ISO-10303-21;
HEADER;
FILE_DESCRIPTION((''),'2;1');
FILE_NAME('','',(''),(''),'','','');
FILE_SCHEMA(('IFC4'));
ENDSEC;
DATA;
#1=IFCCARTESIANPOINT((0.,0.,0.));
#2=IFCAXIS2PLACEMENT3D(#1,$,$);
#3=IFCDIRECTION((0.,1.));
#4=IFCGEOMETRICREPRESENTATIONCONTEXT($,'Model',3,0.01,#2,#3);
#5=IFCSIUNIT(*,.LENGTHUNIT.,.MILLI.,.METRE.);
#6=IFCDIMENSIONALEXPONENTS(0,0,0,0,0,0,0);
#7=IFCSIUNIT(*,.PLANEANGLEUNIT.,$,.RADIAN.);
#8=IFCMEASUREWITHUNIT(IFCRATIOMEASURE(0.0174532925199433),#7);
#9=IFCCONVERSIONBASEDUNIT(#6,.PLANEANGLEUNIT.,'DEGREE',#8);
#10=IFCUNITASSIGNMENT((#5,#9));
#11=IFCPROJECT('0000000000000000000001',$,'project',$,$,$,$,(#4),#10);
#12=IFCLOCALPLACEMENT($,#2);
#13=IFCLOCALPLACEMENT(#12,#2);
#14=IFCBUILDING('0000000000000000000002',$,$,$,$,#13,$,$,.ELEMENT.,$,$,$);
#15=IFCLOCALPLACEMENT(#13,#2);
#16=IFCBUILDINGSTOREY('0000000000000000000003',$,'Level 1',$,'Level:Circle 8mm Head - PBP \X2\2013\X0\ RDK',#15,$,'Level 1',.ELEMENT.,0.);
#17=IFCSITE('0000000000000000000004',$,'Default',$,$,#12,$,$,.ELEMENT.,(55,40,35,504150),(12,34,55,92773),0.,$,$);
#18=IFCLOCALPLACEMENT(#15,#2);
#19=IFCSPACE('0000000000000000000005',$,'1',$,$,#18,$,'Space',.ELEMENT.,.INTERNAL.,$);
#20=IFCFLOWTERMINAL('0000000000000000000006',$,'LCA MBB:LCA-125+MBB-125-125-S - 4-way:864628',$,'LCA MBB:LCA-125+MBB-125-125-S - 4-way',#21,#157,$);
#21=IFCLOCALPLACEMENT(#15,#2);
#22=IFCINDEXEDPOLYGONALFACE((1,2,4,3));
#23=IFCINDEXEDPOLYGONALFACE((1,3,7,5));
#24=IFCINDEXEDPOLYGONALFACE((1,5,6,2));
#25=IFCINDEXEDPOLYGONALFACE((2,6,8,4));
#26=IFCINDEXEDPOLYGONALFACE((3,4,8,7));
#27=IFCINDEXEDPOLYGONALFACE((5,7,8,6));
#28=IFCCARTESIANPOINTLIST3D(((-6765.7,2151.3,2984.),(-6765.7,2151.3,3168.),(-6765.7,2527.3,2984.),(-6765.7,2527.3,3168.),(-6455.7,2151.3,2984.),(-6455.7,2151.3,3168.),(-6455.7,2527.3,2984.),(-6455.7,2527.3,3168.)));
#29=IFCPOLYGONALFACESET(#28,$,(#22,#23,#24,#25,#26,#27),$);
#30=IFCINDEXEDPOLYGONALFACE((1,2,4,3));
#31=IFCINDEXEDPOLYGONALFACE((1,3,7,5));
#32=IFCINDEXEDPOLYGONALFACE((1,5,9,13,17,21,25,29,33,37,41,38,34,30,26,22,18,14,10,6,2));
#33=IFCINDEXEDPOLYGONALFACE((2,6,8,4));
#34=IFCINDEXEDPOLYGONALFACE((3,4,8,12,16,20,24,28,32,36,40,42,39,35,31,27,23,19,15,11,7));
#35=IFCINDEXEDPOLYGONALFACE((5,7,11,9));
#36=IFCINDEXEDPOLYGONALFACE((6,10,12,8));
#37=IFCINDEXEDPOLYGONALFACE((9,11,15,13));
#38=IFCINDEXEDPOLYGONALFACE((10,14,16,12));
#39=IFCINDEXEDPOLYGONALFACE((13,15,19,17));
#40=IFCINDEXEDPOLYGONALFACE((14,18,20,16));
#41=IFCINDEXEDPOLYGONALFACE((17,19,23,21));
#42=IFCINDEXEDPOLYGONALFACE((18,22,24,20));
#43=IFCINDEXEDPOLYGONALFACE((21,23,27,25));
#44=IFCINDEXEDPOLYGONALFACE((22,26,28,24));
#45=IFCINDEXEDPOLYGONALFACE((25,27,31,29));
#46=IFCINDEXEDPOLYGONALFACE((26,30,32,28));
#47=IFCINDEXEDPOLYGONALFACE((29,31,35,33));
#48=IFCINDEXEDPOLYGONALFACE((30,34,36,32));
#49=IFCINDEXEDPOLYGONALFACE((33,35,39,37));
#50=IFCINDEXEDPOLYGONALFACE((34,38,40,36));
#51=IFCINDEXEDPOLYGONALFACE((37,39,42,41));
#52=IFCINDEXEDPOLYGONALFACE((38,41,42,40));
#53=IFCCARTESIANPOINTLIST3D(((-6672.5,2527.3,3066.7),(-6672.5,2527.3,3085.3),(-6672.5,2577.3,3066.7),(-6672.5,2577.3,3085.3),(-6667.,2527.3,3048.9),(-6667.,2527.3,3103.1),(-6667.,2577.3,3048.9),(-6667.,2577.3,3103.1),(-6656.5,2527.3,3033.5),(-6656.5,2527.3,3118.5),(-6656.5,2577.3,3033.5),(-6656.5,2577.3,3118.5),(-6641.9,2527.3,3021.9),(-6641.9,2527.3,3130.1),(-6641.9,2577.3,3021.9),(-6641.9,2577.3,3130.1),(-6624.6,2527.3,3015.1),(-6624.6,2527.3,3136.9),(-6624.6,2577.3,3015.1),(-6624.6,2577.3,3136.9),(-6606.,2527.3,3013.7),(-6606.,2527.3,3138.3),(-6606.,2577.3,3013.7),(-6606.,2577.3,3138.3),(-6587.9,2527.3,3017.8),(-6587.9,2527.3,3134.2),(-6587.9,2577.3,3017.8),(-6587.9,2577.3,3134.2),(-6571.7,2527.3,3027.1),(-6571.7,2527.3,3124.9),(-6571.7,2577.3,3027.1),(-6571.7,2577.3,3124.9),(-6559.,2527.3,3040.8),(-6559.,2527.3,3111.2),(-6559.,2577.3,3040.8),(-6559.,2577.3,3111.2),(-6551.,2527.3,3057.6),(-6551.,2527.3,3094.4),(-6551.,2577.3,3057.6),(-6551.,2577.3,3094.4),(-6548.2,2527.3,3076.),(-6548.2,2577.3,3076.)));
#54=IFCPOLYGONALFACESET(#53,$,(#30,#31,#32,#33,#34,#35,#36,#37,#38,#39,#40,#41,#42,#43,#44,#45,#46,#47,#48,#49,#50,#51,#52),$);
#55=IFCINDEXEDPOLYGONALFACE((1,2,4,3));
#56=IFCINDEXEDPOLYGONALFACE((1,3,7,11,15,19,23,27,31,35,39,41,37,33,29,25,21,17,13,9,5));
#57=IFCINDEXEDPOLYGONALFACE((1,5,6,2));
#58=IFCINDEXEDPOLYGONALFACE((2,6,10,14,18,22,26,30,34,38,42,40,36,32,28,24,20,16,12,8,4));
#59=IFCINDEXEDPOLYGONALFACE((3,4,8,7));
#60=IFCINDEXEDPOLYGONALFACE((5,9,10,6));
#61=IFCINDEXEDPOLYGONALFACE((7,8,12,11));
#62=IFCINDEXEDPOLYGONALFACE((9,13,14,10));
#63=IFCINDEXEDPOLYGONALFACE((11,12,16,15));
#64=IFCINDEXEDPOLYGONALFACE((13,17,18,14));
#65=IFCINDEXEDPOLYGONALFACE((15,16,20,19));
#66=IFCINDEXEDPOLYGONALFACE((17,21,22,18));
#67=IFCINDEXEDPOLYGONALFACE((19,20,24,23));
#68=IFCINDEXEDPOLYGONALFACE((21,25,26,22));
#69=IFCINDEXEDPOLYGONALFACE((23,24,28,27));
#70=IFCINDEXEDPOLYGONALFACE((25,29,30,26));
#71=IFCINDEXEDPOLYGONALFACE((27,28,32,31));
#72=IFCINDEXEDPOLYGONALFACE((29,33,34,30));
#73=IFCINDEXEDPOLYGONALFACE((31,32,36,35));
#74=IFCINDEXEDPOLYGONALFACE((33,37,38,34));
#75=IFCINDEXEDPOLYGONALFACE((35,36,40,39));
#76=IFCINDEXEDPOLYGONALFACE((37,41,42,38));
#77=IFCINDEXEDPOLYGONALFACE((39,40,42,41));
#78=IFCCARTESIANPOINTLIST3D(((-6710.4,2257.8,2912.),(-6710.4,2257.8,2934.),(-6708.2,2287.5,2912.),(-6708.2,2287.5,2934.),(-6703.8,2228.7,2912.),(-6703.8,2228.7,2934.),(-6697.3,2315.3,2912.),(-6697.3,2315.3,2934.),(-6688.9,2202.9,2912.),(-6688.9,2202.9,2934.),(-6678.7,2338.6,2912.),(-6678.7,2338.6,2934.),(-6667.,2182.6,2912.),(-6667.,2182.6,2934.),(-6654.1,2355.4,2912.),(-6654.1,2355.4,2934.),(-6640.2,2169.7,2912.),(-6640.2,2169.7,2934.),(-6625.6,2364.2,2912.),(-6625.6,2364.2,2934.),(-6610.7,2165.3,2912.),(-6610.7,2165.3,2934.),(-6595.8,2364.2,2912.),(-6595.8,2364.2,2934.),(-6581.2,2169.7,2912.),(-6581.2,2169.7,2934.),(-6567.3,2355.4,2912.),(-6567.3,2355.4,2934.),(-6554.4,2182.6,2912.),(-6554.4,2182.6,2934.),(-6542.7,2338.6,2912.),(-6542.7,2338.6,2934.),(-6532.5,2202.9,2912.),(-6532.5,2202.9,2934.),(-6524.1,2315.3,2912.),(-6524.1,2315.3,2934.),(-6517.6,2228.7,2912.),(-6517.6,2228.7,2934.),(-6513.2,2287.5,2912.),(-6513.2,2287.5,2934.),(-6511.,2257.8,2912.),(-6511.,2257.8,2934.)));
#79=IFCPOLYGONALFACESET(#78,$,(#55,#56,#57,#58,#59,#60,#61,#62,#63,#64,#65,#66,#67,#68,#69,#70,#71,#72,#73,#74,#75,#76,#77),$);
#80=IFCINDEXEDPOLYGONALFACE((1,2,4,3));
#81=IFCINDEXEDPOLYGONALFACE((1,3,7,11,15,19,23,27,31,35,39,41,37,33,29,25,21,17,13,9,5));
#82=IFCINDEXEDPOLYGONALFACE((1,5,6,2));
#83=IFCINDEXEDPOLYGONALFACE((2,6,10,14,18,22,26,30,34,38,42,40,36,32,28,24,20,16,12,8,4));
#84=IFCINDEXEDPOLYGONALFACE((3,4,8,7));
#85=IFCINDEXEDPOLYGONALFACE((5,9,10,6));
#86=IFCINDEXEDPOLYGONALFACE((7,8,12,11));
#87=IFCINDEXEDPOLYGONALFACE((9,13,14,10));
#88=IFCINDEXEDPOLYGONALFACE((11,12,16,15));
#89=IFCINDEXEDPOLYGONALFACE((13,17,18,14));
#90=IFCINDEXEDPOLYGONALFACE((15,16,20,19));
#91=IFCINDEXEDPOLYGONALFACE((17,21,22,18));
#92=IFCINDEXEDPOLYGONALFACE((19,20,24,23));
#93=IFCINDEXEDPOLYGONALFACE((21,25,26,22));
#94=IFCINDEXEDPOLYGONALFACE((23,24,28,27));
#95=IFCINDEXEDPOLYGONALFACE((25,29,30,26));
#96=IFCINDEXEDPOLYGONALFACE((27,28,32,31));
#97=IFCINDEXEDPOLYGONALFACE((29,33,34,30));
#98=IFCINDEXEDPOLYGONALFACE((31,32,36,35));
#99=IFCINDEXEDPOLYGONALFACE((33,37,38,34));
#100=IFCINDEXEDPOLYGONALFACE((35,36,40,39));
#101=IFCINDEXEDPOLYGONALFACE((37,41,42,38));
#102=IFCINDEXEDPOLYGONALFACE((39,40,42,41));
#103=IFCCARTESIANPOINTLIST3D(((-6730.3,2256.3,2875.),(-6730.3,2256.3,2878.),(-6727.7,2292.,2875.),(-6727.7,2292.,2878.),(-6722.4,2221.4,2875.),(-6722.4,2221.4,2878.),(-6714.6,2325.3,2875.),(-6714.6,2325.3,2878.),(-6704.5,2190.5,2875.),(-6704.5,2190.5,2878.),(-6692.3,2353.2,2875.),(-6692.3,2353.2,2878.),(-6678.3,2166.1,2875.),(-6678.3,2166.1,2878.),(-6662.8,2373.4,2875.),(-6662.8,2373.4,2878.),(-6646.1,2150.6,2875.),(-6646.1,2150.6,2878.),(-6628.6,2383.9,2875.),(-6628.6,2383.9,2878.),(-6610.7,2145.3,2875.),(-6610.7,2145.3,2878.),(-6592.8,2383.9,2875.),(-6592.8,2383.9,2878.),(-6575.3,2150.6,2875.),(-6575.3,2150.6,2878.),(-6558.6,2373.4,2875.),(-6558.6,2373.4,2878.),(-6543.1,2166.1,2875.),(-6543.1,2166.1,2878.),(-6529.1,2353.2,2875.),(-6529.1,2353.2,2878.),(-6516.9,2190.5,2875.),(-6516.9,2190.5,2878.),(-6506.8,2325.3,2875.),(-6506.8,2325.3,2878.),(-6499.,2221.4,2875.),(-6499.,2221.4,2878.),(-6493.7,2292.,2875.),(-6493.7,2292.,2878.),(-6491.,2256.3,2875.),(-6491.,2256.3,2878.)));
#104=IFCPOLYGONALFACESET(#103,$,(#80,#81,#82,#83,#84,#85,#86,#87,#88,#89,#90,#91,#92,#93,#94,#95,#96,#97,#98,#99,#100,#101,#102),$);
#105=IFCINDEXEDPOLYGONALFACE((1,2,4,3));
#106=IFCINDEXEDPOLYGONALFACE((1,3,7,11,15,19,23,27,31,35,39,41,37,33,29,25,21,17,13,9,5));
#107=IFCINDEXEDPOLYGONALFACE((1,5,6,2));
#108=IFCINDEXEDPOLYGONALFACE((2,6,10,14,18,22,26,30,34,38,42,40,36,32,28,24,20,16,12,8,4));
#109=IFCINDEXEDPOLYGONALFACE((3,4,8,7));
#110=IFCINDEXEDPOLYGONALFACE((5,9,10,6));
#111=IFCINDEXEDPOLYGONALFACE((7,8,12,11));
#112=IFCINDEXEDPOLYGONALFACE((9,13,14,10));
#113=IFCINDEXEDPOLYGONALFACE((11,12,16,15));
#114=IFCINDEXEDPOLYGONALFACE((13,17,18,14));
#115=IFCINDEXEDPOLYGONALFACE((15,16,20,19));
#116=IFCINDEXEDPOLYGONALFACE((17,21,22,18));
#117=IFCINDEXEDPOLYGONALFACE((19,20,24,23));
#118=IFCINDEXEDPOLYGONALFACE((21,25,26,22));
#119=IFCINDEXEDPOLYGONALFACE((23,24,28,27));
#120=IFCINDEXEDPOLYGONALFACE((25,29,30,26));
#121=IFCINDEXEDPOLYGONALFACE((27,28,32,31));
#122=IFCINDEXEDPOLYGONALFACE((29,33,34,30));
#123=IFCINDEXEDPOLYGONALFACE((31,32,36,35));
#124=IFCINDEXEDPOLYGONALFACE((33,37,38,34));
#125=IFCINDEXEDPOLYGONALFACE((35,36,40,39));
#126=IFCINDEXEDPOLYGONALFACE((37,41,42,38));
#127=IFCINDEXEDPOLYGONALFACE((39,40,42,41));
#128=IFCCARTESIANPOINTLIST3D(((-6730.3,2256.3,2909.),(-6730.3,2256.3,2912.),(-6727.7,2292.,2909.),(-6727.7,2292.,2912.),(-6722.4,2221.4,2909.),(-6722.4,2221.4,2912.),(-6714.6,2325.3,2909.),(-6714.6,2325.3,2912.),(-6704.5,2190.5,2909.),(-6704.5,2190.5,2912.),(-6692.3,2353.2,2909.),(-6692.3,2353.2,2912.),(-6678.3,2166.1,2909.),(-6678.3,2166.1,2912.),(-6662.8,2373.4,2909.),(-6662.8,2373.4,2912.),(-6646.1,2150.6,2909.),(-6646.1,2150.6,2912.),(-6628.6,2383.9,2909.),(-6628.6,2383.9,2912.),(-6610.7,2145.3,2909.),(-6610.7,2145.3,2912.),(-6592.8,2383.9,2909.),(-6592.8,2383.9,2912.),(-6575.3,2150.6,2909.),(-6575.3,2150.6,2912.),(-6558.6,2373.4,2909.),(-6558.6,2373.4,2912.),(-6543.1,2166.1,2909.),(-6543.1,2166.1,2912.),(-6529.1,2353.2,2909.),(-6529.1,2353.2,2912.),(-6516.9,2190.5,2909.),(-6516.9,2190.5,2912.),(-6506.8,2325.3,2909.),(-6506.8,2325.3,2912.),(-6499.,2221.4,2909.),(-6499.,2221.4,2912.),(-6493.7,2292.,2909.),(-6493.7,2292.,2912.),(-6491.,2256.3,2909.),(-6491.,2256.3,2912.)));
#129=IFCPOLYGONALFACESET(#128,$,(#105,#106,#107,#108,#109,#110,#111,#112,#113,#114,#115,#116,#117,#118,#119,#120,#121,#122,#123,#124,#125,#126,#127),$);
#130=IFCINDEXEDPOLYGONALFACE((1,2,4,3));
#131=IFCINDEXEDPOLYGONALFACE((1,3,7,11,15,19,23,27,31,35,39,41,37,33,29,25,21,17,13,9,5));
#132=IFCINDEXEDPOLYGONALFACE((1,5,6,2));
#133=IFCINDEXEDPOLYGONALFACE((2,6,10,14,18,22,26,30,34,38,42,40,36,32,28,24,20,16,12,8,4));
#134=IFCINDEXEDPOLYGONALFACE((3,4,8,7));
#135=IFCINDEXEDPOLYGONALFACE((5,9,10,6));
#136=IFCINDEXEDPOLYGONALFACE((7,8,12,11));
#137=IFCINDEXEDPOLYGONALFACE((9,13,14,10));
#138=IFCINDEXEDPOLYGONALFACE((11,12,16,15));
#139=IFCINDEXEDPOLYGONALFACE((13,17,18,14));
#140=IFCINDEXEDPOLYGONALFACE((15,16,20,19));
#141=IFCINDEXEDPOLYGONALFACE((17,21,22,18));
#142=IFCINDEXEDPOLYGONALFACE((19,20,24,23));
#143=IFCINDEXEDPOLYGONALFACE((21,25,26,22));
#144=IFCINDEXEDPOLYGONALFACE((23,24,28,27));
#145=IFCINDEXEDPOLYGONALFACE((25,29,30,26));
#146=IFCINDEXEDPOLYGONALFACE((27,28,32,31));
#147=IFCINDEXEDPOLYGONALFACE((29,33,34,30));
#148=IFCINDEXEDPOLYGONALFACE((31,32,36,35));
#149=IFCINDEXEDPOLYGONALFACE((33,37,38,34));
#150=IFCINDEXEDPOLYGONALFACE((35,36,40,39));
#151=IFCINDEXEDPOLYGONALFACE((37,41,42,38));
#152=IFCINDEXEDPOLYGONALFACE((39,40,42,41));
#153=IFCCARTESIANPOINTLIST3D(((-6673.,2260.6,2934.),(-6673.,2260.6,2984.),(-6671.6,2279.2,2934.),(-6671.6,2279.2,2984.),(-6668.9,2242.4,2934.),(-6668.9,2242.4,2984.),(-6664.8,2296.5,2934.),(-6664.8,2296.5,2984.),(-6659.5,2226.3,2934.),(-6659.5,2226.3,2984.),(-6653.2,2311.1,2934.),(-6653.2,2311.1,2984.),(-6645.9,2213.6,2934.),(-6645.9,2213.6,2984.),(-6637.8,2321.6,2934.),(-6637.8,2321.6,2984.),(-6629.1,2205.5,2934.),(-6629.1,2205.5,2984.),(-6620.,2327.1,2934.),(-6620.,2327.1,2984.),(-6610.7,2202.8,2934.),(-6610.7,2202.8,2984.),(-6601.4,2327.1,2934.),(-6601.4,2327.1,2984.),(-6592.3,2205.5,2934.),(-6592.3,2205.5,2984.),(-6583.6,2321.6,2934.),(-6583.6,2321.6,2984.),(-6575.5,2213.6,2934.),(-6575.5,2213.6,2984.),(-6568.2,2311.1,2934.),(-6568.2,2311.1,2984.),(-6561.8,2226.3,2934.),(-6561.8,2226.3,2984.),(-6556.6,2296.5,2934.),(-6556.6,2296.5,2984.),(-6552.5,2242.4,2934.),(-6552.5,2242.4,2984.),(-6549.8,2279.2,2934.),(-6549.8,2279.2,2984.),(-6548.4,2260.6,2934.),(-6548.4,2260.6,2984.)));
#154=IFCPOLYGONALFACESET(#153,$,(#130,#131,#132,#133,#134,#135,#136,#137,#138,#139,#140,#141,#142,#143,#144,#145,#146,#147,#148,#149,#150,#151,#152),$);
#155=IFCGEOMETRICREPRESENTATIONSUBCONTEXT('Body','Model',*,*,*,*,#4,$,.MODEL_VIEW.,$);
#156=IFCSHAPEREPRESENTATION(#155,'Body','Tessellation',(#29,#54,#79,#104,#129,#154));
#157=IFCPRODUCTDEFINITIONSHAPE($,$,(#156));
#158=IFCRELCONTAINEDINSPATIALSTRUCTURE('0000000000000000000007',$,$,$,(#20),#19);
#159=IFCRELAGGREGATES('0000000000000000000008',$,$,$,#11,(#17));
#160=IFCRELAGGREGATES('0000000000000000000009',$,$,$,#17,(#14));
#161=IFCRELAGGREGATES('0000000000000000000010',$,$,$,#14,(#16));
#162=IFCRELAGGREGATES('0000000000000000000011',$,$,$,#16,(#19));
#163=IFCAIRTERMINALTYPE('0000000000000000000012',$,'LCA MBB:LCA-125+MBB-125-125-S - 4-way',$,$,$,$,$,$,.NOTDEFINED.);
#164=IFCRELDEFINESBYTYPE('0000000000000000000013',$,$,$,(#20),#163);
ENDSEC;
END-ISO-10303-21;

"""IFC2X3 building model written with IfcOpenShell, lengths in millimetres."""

from ifc_helpers import new_model, entity, si_unit, converted_unit, direction, frame, frame_2d, origin, origin_2d_with_axis, place, context, subcontext, project, spatial, rectangle, circle, extrude, source, transform, mapped, type_object, type_shapes, element, save


model = new_model("IFC2X3")

# Units and contexts
model_context = context("Model", 3, precision=0.01, world=origin(), true_north=direction((0.0, 1.0)))
body_context = subcontext(model_context, "Body", "Model", "MODEL_VIEW")
ifc_project = project(units=[si_unit("LENGTHUNIT", "METRE", prefix="MILLI"), converted_unit("PLANEANGLEUNIT", "DEGREE", entity("IfcRatioMeasure", 0.0174532925199433), si_unit("PLANEANGLEUNIT", "RADIAN"), dimensions=[0, 0, 0, 0, 0, 0, 0])], contexts=[model_context])

# Site, building, storey, space
site_placement = place(None, origin())
site = spatial("IfcSite", under=ifc_project, at=site_placement, Name="Default", CompositionType="ELEMENT", RefLatitude=(55, 40, 35, 504150), RefLongitude=(12, 34, 55, 92773), RefElevation=0.0)
building_placement = place(site_placement, origin())
building = spatial("IfcBuilding", under=site, at=building_placement, CompositionType="ELEMENT")
storey_placement = place(building_placement, origin())
storey = spatial("IfcBuildingStorey", under=building, at=storey_placement, Name="Level 1", ObjectType="Level:Circle 8mm Head - PBP – RDK", LongName="Level 1", CompositionType="ELEMENT", Elevation=0.0)
space_1_placement = place(storey_placement, origin())
space_1 = spatial("IfcSpace", under=storey, at=space_1_placement, Name="1", LongName="Space", CompositionType="ELEMENT", InteriorOrExteriorSpace="INTERNAL")

# Flow terminal
air_terminal_type_1 = type_object("IfcAirTerminalType", Name="LCA MBB:LCA-125+MBB-125-125-S - 4-way", PredefinedType="NOTDEFINED")
shared_shape_1 = source(origin(), body_context, "Body", "SweptSolid", [
    extrude(rectangle(XDim=310.0, YDim=376.0, at=origin_2d_with_axis()), frame((-74.0, 0.0, 72.0), z_axis=(0.0, 0.0, 1.0), x_axis=(0.0, -1.0, 0.0)), (0.0, 0.0, 1.0), 184.0),
    extrude(circle(Radius=62.5, at=frame_2d((0.0, 0.0), x_axis=(1.0, 0.0))), frame((-312.0, 0.0, 164.0), z_axis=(1.0, 0.0, 0.0), x_axis=(0.0, 1.0, 0.0)), (0.0, 0.0, 1.0), 50.0),
    extrude(circle(Radius=100.0, at=frame_2d((0.0, 0.0), x_axis=(1.0, 0.0))), origin(), (0.0, 0.0, 1.0), 22.0),
    extrude(circle(Radius=120.0, at=frame_2d((0.0, 0.0), x_axis=(1.0, 0.0))), frame((0.0, 0.0, -37.0)), (0.0, 0.0, 1.0), 3.0),
    extrude(circle(Radius=120.0, at=frame_2d((0.0, 0.0), x_axis=(1.0, 0.0))), frame((0.0, 0.0, -3.0)), (0.0, 0.0, 1.0), 3.0),
    extrude(circle(Radius=62.5, at=frame_2d((0.0, 0.0), x_axis=(1.0, 0.0))), frame((0.0, 0.0, 22.0)), (0.0, 0.0, 1.0), 50.0),
])
type_shapes(air_terminal_type_1, [shared_shape_1])
flow_terminal_1_placement = place(space_1_placement, frame((-6610.7, 2265.3, 2912.0), z_axis=(0.0, 0.0, 1.0), x_axis=(0.0, -1.0, 0.0)))
element("IfcFlowTerminal", 1, at=flow_terminal_1_placement, inside=space_1, type_object=air_terminal_type_1, Name="LCA MBB:LCA-125+MBB-125-125-S - 4-way:864628", ObjectType="LCA MBB:LCA-125+MBB-125-125-S - 4-way", context=body_context, shape_type="MappedRepresentation", body=[
    mapped(shared_shape_1, transform((0.0, 0.0, 0.0), scale=1.0)),
])

save(model, "model.ifc")
